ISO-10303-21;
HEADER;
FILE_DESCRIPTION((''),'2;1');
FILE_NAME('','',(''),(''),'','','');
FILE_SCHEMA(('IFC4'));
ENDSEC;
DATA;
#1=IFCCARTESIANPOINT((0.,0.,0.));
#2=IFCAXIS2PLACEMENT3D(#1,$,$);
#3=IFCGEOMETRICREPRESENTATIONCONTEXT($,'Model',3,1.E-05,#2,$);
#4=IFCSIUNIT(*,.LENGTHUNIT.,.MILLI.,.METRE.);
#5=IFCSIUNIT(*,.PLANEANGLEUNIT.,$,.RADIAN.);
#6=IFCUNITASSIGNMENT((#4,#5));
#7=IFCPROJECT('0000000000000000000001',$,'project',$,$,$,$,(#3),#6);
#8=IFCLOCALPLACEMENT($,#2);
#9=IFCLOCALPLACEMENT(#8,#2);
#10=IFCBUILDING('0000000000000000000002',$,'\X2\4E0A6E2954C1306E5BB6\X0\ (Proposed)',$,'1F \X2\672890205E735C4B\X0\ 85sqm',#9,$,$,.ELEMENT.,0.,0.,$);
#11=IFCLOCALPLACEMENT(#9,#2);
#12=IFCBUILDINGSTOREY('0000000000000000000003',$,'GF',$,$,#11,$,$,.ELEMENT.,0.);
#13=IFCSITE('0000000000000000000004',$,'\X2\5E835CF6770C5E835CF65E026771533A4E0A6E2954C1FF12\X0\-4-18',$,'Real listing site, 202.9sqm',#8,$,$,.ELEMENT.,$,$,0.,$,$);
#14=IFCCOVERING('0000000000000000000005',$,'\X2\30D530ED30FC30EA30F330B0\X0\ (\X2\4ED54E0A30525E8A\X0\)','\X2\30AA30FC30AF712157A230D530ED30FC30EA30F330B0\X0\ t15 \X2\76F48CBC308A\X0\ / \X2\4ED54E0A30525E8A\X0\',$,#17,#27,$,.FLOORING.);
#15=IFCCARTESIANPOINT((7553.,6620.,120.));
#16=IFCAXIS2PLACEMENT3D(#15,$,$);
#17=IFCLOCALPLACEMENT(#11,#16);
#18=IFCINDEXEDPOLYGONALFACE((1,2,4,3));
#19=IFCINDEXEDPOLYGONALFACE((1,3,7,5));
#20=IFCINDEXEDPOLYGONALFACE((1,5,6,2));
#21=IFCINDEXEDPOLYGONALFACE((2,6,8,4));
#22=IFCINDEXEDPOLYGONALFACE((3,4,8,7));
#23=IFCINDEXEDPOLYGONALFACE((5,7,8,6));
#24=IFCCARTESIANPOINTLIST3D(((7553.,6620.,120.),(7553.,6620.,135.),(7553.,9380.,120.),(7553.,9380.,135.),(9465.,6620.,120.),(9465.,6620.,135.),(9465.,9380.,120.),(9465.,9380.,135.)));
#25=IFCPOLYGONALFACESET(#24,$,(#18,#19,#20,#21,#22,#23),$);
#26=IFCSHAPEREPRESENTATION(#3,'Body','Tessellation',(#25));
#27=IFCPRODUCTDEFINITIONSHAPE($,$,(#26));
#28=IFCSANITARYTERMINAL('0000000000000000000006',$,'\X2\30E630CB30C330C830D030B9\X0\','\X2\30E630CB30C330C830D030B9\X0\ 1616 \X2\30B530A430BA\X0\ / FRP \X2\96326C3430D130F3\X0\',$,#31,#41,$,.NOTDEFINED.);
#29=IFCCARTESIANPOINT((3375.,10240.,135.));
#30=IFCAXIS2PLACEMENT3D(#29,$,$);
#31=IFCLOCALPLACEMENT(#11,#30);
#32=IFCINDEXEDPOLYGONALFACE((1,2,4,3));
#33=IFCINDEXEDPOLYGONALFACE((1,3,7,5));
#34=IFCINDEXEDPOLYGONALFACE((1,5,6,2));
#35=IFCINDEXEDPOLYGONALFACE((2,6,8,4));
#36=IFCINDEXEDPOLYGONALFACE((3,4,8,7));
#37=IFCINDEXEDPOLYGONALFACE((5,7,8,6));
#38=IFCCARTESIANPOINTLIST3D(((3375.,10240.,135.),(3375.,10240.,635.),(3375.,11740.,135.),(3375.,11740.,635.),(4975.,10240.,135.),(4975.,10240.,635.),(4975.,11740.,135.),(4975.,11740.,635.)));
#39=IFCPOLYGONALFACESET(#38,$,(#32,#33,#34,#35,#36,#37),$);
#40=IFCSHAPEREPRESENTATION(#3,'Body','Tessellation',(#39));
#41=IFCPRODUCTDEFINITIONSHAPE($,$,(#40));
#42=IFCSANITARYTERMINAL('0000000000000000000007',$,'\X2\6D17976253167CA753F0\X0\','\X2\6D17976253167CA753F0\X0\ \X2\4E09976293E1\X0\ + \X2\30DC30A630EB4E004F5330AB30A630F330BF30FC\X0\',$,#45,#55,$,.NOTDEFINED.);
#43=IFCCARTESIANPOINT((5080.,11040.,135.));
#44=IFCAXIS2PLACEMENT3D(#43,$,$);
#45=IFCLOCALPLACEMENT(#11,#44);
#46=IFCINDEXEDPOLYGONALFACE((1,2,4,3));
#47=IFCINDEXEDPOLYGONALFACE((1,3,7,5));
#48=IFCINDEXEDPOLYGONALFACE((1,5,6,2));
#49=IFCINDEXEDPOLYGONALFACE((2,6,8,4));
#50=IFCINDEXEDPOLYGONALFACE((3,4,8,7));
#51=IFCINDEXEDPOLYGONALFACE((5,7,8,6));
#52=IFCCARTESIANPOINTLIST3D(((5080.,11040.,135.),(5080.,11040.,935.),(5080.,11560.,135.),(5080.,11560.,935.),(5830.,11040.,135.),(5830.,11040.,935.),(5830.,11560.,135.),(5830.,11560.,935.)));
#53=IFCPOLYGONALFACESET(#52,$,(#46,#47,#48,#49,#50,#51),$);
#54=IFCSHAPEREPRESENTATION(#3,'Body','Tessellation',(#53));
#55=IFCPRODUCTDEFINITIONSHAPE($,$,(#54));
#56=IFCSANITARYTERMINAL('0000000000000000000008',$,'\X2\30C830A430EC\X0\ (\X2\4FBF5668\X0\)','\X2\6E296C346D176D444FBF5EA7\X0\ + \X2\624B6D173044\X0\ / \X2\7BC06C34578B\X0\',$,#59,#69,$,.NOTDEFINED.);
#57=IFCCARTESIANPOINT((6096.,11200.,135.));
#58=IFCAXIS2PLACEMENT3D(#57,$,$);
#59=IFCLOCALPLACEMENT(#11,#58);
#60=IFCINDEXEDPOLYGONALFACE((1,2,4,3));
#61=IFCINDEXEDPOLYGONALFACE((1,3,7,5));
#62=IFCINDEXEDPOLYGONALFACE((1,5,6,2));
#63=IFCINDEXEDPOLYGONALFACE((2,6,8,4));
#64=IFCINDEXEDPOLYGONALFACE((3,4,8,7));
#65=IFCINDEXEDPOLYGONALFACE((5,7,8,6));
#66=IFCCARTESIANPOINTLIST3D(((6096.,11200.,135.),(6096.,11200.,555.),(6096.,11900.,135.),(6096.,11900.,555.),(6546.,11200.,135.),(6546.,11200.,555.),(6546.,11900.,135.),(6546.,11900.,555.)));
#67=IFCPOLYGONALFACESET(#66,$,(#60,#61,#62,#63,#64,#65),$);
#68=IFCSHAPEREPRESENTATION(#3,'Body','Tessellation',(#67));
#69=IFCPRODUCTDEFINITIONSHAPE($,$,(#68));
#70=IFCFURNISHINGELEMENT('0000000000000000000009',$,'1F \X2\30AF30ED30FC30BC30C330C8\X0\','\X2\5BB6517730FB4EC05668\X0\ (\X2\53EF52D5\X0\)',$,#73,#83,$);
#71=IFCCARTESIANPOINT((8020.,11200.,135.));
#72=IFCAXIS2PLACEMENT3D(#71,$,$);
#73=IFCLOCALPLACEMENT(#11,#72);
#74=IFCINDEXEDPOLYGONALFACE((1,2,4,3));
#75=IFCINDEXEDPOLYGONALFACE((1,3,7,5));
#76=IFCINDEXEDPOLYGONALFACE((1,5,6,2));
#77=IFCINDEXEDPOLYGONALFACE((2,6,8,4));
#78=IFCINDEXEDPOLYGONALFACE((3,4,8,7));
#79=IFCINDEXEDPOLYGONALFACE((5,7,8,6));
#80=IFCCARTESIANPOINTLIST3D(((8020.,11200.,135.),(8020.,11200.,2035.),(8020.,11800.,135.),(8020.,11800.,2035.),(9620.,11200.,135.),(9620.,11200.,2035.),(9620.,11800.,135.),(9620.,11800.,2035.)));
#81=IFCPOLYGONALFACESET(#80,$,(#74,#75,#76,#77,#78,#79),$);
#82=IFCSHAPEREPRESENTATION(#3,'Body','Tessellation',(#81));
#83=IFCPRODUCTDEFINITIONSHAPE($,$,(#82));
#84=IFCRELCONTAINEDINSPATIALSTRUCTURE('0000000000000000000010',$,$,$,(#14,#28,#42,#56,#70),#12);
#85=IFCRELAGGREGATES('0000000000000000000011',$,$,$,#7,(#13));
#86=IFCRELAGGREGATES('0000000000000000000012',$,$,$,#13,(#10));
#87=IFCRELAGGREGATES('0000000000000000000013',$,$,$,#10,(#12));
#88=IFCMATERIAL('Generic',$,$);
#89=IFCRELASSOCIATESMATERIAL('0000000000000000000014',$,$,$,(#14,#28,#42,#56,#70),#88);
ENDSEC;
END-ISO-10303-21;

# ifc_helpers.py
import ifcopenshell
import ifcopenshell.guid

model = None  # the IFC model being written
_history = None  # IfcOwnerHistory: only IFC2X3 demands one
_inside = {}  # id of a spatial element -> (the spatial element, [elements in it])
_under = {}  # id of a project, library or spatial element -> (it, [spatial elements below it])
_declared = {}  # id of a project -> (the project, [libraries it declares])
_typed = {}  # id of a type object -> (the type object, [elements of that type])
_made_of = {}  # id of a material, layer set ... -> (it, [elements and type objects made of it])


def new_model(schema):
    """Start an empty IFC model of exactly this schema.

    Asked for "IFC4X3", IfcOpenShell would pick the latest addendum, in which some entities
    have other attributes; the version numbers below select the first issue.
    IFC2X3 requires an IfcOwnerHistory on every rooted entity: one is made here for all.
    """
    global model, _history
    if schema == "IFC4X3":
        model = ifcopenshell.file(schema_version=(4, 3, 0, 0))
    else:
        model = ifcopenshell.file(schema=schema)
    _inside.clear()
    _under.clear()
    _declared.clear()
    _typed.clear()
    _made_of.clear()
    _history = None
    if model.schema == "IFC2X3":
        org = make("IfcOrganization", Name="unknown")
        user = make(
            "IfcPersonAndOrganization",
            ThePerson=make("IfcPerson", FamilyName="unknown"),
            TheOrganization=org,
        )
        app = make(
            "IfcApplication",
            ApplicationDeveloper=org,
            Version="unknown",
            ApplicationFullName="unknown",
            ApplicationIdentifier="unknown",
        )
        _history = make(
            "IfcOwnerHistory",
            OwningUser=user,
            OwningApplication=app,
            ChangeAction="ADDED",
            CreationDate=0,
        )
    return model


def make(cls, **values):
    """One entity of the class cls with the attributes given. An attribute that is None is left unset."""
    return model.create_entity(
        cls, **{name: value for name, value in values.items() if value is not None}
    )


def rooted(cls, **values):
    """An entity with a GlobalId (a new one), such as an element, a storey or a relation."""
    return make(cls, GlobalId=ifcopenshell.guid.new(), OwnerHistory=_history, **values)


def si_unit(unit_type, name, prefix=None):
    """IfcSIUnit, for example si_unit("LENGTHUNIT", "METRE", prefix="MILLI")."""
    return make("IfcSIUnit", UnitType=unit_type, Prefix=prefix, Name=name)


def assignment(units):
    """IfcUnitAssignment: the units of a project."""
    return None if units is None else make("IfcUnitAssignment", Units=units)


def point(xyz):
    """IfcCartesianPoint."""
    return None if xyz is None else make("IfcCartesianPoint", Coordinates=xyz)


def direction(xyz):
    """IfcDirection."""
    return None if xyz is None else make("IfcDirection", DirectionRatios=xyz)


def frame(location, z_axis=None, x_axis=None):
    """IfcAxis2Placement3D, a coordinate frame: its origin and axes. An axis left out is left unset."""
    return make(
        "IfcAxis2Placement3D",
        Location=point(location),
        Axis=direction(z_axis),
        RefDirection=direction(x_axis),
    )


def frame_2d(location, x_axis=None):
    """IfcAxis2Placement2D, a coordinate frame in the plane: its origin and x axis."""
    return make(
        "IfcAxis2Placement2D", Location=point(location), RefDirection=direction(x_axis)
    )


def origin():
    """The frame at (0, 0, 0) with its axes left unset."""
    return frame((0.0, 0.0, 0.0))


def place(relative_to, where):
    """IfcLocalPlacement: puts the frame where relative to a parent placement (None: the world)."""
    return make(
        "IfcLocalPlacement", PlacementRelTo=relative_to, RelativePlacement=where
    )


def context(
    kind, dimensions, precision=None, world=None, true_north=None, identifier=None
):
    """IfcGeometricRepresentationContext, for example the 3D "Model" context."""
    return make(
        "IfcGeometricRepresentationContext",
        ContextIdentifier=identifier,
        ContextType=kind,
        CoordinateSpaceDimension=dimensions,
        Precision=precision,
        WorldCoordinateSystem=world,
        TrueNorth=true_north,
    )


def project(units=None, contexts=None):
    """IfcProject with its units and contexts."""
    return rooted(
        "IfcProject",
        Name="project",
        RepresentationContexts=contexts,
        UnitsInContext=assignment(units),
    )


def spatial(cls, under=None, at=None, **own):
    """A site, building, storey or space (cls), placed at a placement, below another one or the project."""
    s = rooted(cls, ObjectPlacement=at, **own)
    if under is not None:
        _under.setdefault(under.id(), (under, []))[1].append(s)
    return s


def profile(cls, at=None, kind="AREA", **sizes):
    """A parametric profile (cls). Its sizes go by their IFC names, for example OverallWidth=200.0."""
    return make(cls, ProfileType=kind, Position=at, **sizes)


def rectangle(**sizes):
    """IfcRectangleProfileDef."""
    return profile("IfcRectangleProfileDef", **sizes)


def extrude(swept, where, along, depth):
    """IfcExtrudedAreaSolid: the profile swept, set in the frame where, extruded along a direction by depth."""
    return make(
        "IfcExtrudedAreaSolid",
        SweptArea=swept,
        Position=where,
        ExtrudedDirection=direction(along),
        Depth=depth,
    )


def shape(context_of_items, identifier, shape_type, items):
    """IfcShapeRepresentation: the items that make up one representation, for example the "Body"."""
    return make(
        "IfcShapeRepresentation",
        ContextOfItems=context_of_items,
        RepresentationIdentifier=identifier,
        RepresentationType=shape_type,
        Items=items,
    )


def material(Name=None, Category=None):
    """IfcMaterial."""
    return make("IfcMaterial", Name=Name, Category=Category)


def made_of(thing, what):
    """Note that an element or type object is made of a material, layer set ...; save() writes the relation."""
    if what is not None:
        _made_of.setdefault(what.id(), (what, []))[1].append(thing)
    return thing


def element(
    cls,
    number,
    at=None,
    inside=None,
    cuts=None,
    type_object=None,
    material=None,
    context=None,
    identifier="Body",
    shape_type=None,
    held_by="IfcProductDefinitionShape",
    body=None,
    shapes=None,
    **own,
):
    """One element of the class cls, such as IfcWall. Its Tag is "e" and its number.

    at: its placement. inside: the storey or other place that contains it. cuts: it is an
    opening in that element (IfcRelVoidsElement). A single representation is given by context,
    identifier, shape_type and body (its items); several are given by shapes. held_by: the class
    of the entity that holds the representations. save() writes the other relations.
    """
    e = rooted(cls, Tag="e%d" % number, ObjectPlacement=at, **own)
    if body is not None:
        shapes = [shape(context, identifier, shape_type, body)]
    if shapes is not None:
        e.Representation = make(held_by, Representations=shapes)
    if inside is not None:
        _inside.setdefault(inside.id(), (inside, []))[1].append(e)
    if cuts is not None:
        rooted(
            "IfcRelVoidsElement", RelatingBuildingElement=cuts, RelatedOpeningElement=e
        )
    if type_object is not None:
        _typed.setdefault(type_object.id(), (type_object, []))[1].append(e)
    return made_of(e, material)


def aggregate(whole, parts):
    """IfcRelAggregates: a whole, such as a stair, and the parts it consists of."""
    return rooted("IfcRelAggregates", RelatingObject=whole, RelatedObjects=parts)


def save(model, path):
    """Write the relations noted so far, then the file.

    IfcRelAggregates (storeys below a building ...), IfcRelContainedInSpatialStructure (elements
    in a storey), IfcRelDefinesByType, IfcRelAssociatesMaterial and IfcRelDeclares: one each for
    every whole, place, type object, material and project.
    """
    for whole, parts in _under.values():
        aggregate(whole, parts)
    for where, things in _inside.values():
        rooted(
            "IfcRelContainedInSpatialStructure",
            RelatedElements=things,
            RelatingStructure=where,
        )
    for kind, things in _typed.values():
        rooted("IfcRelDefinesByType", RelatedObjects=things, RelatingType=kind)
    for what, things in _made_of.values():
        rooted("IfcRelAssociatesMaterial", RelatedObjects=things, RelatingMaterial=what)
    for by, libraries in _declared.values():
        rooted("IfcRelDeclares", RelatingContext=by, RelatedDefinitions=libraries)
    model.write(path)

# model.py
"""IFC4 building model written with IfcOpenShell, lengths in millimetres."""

from ifc_helpers import new_model, si_unit, frame, frame_2d, origin, place, context, project, spatial, rectangle, extrude, material, element, save


model = new_model("IFC4")

# Units and contexts
model_context = context("Model", 3, precision=1e-05, world=origin())
ifc_project = project(units=[si_unit("LENGTHUNIT", "METRE", prefix="MILLI"), si_unit("PLANEANGLEUNIT", "RADIAN")], contexts=[model_context])

# Site, building, storey
site_placement = place(None, origin())
site = spatial("IfcSite", under=ifc_project, at=site_placement, Name="広島県広島市東区上温品２-4-18", ObjectType="Real listing site, 202.9sqm", CompositionType="ELEMENT", RefElevation=0.0)
building_placement = place(site_placement, origin())
building = spatial("IfcBuilding", under=site, at=building_placement, Name="上温品の家 (Proposed)", ObjectType="1F 木造平屋 85sqm", CompositionType="ELEMENT", ElevationOfRefHeight=0.0, ElevationOfTerrain=0.0)
storey_placement = place(building_placement, origin())
storey = spatial("IfcBuildingStorey", under=building, at=storey_placement, Name="GF", CompositionType="ELEMENT", Elevation=0.0)

# Covering
ifc_material_1 = material(Name="Generic")
covering_1_placement = place(storey_placement, frame((7553.0, 6620.0, 120.0)))
element("IfcCovering", 1, at=covering_1_placement, inside=storey, material=ifc_material_1, Name="フローリング (仕上げ床)", Description="オーク無垢フローリング t15 直貼り / 仕上げ床", PredefinedType="FLOORING", context=model_context, shape_type="SweptSolid", body=[
    extrude(rectangle(XDim=1912.0, YDim=2760.0, at=frame_2d((956.0, 1380.0))), frame((7553.0, 6620.0, 120.0)), (0.0, 0.0, 1.0), 15.0),
])

# Sanitary terminals
sanitary_terminal_1_placement = place(storey_placement, frame((3375.0, 10240.0, 135.0)))
element("IfcSanitaryTerminal", 2, at=sanitary_terminal_1_placement, inside=storey, material=ifc_material_1, Name="ユニットバス", Description="ユニットバス 1616 サイズ / FRP 防水パン", PredefinedType="NOTDEFINED", context=model_context, shape_type="SweptSolid", body=[
    extrude(rectangle(XDim=1600.0, YDim=1500.0, at=frame_2d((800.0, 750.0))), frame((3375.0, 10240.0, 135.0)), (0.0, 0.0, 1.0), 500.0),
])
sanitary_terminal_2_placement = place(storey_placement, frame((5080.0, 11040.0, 135.0)))
element("IfcSanitaryTerminal", 3, at=sanitary_terminal_2_placement, inside=storey, material=ifc_material_1, Name="洗面化粧台", Description="洗面化粧台 三面鏡 + ボウル一体カウンター", PredefinedType="NOTDEFINED", context=model_context, shape_type="SweptSolid", body=[
    extrude(rectangle(XDim=750.0, YDim=520.0, at=frame_2d((375.0, 260.0))), frame((5080.0, 11040.0, 135.0)), (0.0, 0.0, 1.0), 800.0),
])
sanitary_terminal_3_placement = place(storey_placement, frame((6096.0, 11200.0, 135.0)))
element("IfcSanitaryTerminal", 4, at=sanitary_terminal_3_placement, inside=storey, material=ifc_material_1, Name="トイレ (便器)", Description="温水洗浄便座 + 手洗い / 節水型", PredefinedType="NOTDEFINED", context=model_context, shape_type="SweptSolid", body=[
    extrude(rectangle(XDim=450.0, YDim=700.0, at=frame_2d((225.0, 350.0))), frame((6096.0, 11200.0, 135.0)), (0.0, 0.0, 1.0), 420.0),
])

# Furnishing element
furnishing_placement = place(storey_placement, frame((8020.0, 11200.0, 135.0)))
element("IfcFurnishingElement", 5, at=furnishing_placement, inside=storey, material=ifc_material_1, Name="1F クローゼット", Description="家具・什器 (可動)", context=model_context, shape_type="SweptSolid", body=[
    extrude(rectangle(XDim=1600.0, YDim=600.0, at=frame_2d((800.0, 300.0))), frame((8020.0, 11200.0, 135.0)), (0.0, 0.0, 1.0), 1900.0),
])

save(model, "model.ifc")
